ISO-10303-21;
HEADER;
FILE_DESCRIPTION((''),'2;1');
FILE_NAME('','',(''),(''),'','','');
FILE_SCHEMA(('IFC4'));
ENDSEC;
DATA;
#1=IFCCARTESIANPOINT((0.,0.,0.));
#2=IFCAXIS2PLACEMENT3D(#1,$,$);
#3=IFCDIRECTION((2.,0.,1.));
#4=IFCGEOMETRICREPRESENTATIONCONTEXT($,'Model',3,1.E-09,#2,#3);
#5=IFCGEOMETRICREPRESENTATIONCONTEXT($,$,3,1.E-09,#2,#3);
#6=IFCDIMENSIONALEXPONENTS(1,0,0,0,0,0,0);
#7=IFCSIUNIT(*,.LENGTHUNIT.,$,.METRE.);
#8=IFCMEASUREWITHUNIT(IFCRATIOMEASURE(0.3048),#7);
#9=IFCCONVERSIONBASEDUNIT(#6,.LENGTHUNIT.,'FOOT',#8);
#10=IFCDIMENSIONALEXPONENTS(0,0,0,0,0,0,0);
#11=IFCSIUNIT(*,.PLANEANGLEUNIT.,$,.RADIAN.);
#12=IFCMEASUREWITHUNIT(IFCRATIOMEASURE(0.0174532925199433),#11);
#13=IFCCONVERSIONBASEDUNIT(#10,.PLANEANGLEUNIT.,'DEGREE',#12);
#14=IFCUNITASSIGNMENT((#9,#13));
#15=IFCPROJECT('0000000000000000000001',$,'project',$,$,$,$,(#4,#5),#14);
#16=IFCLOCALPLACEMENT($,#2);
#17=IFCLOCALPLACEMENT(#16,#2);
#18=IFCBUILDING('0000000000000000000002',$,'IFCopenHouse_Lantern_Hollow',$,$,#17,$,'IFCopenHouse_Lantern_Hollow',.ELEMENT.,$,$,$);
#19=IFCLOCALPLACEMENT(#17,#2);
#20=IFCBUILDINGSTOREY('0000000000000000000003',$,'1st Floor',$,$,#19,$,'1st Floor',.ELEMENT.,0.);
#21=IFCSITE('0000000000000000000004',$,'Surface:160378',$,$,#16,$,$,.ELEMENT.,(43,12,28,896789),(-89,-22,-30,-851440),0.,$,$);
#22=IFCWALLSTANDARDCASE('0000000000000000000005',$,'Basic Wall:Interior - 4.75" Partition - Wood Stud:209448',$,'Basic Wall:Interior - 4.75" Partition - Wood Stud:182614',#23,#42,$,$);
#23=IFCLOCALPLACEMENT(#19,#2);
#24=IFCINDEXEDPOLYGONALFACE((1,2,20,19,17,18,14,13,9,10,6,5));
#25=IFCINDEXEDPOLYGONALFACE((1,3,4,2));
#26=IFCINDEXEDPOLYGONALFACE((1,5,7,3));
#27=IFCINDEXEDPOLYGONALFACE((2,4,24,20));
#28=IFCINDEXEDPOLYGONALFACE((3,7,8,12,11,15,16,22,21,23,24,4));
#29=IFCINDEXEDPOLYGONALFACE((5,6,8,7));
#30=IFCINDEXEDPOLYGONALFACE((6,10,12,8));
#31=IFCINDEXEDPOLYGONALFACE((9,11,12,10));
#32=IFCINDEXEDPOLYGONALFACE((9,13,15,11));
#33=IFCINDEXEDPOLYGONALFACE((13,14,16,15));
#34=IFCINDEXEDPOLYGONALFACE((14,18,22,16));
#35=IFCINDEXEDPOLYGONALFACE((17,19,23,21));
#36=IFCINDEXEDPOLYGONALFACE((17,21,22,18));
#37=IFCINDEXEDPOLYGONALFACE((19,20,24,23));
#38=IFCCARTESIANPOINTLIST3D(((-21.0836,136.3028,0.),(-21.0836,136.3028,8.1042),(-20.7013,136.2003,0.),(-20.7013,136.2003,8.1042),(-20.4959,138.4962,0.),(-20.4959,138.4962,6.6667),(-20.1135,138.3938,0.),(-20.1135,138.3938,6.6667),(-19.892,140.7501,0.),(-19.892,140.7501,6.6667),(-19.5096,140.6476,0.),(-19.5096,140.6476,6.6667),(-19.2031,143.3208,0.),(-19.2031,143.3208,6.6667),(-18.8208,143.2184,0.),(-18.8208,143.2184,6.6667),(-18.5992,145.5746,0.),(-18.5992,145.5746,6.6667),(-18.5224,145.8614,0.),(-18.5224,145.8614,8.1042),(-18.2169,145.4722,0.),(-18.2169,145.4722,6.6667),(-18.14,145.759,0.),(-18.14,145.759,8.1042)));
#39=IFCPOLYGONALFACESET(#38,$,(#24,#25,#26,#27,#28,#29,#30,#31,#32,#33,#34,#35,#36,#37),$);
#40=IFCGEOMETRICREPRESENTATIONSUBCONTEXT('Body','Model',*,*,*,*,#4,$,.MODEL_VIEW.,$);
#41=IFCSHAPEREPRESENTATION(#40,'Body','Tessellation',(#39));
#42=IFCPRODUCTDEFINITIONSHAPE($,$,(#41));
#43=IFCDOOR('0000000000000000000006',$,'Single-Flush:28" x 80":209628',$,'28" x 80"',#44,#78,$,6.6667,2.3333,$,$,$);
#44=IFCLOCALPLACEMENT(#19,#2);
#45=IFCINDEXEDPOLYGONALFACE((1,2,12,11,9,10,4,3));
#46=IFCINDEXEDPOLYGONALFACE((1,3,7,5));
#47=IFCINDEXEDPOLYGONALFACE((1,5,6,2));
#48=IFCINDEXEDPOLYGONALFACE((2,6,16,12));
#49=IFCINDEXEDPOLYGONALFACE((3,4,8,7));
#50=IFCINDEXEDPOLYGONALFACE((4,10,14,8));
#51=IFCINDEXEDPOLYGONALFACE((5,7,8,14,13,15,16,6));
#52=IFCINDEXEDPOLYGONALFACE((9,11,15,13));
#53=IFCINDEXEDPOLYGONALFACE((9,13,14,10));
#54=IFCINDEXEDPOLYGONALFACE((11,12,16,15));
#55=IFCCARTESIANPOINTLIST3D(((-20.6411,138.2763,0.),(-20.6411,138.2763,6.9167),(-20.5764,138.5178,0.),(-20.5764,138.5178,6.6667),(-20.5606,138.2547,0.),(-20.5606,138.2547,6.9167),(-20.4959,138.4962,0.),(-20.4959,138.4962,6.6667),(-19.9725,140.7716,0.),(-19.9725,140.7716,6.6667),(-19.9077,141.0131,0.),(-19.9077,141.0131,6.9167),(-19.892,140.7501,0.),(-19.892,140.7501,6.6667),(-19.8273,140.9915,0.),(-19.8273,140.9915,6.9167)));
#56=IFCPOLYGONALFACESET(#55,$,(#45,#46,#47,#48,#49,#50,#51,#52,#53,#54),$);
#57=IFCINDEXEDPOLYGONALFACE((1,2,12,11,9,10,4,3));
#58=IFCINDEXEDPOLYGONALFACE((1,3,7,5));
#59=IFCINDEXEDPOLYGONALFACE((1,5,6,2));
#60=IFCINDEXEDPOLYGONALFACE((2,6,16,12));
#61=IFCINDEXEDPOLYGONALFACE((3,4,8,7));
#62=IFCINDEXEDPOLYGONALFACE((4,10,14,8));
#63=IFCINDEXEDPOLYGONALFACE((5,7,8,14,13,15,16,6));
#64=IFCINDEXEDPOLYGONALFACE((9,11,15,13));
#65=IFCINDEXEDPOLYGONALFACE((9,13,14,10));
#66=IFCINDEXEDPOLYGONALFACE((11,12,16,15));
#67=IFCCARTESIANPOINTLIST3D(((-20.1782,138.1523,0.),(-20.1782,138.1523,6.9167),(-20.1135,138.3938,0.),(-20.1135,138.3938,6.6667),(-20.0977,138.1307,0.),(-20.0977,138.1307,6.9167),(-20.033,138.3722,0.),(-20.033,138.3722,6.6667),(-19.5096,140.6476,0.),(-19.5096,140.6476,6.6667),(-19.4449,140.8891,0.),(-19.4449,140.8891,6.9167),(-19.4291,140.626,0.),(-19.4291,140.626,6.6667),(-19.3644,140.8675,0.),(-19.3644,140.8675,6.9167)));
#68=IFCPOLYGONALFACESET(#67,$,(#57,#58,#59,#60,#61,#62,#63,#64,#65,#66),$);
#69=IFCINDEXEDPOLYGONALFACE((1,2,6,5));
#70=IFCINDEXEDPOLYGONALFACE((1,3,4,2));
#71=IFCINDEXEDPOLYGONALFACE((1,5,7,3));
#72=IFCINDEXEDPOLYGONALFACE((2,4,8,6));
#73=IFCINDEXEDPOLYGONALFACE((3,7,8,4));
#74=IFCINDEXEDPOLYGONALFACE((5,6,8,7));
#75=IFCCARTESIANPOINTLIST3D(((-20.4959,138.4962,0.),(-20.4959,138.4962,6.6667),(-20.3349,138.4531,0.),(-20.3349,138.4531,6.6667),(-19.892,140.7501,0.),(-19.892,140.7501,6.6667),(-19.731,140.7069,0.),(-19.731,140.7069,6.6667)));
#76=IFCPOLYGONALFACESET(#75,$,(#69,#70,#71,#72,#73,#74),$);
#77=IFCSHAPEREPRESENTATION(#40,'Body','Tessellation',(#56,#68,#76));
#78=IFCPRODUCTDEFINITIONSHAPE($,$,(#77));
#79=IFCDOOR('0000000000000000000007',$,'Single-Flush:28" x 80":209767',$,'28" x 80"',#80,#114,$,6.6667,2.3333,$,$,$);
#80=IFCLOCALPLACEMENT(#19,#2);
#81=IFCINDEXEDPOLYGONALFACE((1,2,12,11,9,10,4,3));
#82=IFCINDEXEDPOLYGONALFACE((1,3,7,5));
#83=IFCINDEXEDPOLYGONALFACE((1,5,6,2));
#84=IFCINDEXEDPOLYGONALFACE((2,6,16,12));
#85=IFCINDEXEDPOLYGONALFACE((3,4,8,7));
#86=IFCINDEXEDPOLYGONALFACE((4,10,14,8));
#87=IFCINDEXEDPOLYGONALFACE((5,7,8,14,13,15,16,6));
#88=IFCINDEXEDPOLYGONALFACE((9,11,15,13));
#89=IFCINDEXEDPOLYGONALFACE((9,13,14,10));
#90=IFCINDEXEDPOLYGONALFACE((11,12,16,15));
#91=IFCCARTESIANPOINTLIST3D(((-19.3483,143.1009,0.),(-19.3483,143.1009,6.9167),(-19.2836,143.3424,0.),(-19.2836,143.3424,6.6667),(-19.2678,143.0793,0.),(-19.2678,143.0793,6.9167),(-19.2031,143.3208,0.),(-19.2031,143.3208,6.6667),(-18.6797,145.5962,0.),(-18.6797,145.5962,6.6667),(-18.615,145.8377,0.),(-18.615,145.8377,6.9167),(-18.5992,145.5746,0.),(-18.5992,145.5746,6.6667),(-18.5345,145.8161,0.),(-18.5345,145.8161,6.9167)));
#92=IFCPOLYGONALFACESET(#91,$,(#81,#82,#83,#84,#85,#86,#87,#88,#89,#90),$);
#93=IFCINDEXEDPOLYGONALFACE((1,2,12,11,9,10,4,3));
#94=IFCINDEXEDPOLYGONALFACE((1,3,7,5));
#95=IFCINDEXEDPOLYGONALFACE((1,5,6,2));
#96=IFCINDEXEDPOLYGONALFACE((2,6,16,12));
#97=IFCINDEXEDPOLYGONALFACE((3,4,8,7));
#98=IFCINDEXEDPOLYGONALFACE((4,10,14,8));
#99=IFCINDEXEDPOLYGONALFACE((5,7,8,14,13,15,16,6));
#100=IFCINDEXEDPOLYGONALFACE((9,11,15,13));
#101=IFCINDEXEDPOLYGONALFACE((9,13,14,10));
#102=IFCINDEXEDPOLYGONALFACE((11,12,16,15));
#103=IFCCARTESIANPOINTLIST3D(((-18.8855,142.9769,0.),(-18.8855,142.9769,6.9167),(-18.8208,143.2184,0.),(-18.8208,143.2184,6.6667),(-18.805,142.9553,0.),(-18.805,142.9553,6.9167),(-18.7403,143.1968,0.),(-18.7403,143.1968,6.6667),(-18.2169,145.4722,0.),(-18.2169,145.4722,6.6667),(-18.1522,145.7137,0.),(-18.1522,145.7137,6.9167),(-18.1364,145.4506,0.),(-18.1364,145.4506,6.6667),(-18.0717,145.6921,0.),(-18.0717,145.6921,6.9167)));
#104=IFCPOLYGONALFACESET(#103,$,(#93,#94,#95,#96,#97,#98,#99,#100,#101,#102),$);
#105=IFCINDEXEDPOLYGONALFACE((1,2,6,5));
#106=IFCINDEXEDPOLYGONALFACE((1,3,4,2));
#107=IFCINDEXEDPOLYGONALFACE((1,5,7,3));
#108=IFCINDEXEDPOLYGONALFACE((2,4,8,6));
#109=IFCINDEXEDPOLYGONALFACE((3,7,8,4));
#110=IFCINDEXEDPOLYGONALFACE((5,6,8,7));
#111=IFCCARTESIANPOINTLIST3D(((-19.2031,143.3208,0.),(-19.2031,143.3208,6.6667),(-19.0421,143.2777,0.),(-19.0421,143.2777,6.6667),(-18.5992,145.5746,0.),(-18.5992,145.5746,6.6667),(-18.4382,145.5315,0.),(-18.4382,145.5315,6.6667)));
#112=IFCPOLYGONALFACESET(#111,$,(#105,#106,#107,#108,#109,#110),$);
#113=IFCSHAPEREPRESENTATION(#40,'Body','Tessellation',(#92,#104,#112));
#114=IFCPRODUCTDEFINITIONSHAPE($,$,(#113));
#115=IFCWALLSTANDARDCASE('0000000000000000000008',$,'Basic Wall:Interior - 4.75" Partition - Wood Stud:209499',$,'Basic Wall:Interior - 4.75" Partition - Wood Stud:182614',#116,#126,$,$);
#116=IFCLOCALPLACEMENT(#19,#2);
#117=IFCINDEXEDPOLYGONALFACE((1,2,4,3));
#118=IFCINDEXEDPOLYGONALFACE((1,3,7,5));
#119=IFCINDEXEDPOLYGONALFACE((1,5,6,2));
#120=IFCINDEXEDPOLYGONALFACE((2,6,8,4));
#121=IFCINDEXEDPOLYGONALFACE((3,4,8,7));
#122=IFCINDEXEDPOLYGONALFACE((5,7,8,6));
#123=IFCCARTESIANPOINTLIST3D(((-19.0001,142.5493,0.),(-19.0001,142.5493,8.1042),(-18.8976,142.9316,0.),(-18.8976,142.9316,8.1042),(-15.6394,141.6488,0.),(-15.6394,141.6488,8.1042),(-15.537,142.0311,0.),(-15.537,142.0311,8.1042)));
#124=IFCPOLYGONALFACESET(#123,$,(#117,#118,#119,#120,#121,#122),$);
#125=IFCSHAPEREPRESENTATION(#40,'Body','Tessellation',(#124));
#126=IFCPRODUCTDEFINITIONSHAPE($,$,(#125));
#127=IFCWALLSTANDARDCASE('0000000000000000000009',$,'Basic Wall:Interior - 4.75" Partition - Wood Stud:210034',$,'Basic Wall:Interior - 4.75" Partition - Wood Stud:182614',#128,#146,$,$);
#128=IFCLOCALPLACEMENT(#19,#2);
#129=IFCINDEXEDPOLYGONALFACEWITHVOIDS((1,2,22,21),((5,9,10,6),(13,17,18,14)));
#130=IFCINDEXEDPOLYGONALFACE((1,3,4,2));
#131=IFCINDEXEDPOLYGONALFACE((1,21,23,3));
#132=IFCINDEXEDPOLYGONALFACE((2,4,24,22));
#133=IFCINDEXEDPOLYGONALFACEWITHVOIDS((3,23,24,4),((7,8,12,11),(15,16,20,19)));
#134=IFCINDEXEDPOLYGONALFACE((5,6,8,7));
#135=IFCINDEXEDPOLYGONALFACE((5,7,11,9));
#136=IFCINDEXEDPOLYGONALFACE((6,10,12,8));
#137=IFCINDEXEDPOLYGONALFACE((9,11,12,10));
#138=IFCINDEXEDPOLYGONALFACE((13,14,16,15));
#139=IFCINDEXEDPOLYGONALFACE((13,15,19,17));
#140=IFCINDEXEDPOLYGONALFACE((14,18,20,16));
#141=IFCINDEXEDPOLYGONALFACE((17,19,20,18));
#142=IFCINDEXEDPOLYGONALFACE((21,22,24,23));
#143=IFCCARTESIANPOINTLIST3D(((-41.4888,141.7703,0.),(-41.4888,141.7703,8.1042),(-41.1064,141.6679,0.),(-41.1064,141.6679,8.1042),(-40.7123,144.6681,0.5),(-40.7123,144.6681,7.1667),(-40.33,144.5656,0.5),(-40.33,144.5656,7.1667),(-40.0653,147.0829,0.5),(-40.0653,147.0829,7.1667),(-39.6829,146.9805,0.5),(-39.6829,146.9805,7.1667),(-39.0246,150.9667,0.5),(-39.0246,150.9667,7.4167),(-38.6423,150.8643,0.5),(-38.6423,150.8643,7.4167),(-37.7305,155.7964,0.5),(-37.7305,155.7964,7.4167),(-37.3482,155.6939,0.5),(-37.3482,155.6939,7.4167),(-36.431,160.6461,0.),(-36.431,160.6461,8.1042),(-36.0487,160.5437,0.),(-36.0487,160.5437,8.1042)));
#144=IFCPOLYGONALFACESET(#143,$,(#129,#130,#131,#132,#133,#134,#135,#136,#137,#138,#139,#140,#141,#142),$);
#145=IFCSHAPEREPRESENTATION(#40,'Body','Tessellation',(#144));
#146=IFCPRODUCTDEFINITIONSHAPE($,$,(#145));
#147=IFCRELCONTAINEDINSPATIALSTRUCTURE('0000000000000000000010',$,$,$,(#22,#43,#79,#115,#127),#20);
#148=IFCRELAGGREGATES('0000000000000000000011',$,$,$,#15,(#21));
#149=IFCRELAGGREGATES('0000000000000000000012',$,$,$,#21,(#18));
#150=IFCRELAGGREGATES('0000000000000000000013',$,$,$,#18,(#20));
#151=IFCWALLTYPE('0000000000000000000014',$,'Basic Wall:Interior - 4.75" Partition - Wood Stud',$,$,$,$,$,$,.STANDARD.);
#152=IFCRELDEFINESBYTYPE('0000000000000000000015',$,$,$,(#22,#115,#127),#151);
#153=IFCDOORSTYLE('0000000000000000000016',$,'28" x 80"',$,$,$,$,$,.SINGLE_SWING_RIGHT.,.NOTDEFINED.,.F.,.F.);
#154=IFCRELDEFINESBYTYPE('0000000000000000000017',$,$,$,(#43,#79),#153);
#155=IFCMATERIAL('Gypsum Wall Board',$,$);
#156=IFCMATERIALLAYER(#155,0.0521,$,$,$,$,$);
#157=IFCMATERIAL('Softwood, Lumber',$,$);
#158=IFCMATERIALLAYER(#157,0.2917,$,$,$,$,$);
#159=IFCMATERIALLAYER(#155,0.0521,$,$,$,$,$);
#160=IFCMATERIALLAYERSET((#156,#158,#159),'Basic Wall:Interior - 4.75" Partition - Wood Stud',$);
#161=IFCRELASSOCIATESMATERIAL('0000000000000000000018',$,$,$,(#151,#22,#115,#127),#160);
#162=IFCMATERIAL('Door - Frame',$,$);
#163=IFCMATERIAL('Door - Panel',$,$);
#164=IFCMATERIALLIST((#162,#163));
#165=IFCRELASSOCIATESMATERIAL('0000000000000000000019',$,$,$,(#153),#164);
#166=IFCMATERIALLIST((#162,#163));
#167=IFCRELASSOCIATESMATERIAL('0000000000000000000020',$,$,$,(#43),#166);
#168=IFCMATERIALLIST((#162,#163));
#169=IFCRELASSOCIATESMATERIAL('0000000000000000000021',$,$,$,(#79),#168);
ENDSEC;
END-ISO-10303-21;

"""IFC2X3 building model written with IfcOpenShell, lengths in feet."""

from ifc_helpers import new_model, entity, si_unit, converted_unit, direction, frame, frame_2d, origin, origin_2d_with_axis, place, context, subcontext, project, spatial, polyline, rectangle, outline, extrude, source, transform, mapped, material, material_list, layer, layer_set, layer_usage, type_object, type_shapes, element, fill, save


model = new_model("IFC2X3")

# Units and contexts
model_context = context("Model", 3, precision=1e-09, world=origin(), true_north=direction((2.0, 0.0, 1.0)))
context_of_model = context(None, 3, precision=1e-09, world=origin(), true_north=direction((2.0, 0.0, 1.0)))
body_context = subcontext(model_context, "Body", "Model", "MODEL_VIEW")
ifc_project = project(units=[converted_unit("LENGTHUNIT", "FOOT", entity("IfcRatioMeasure", 0.3048), si_unit("LENGTHUNIT", "METRE"), dimensions=[1, 0, 0, 0, 0, 0, 0]), converted_unit("PLANEANGLEUNIT", "DEGREE", entity("IfcRatioMeasure", 0.0174532925199433), si_unit("PLANEANGLEUNIT", "RADIAN"), dimensions=[0, 0, 0, 0, 0, 0, 0])], contexts=[model_context, context_of_model])

# Site, building, storey
site_placement = place(None, origin())
site = spatial("IfcSite", under=ifc_project, at=site_placement, Name="Surface:160378", CompositionType="ELEMENT", RefLatitude=(43, 12, 28, 896789), RefLongitude=(-89, -22, -30, -851440), RefElevation=0.0)
building_placement = place(site_placement, origin())
building = spatial("IfcBuilding", under=site, at=building_placement, Name="IFCopenHouse_Lantern_Hollow", LongName="IFCopenHouse_Lantern_Hollow", CompositionType="ELEMENT")
storey_placement = place(building_placement, origin())
storey = spatial("IfcBuildingStorey", under=building, at=storey_placement, Name="1st Floor", LongName="1st Floor", CompositionType="ELEMENT", Elevation=0.0)

# Shared definitions
ifc_material_1 = material(Name="Gypsum Wall Board")
ifc_layer_1 = layer(ifc_material_1, 0.0521)
ifc_material_2 = material(Name="Softwood, Lumber")
ifc_layer_2 = layer(ifc_material_2, 0.2917)
ifc_layer_3 = layer(ifc_material_1, 0.0521)
ifc_layer_set_1 = layer_set([ifc_layer_1, ifc_layer_2, ifc_layer_3], Name="Basic Wall:Interior - 4.75\" Partition - Wood Stud")
wall_type_1 = type_object("IfcWallType", Name="Basic Wall:Interior - 4.75\" Partition - Wood Stud", PredefinedType="STANDARD", material=ifc_layer_set_1)

# Shared definitions
ifc_material_3 = material(Name="Door - Panel")
ifc_material_4 = material(Name="Door - Frame")

# Wall, openings, doors
ifc_layer_usage_1 = layer_usage(ifc_layer_set_1, "AXIS2", "NEGATIVE", 0.1979)
wall_1_placement = place(storey_placement, frame((-18.3312, 145.8102, 0.0), z_axis=(0.0, 0.0, 1.0), x_axis=(-0.258819, -0.965926, 0.0)))
wall_1 = element("IfcWallStandardCase", 1, at=wall_1_placement, inside=storey, type_object=wall_type_1, material=ifc_layer_usage_1, Name="Basic Wall:Interior - 4.75\" Partition - Wood Stud:209448", ObjectType="Basic Wall:Interior - 4.75\" Partition - Wood Stud:182614", context=body_context, shape_type="SweptSolid", body=[
    extrude(rectangle(XDim=9.8958, YDim=0.3958, at=frame_2d((4.9479, 0.0), x_axis=(-1.0, 0.0))), origin(), (0.0, 0.0, 1.0), 8.1042),
])
opening_1_placement = place(wall_1_placement, frame((7.625, 0.1979, 0.0)))
opening_1 = element("IfcOpeningElement", 2, at=opening_1_placement, cuts=wall_1, ObjectType="Opening", context=body_context, shape_type="SweptSolid", body=[
    extrude(rectangle(XDim=2.3333, YDim=6.6667, at=frame_2d((3.3333, 1.1667), x_axis=(0.0, 1.0))), frame((0.0, 0.0, 0.0), z_axis=(0.0, -1.0, 0.0), x_axis=(0.0, 0.0, 1.0)), (0.0, 0.0, 1.0), 0.3958),
])
opening_2_placement = place(wall_1_placement, frame((2.6302, 0.1979, 0.0)))
opening_2 = element("IfcOpeningElement", 3, at=opening_2_placement, cuts=wall_1, ObjectType="Opening", context=body_context, shape_type="SweptSolid", body=[
    extrude(rectangle(XDim=2.3333, YDim=6.6667, at=frame_2d((3.3333, 1.1667), x_axis=(0.0, 1.0))), frame((0.0, 0.0, 0.0), z_axis=(0.0, -1.0, 0.0), x_axis=(0.0, 0.0, 1.0)), (0.0, 0.0, 1.0), 0.3958),
])
ifc_material_list_1 = material_list([ifc_material_4, ifc_material_3])
ifc_material_list_2 = material_list([ifc_material_4, ifc_material_3])
door_style_1 = type_object("IfcDoorStyle", Name="28\" x 80\"", ConstructionType="NOTDEFINED", OperationType="SINGLE_SWING_RIGHT", ParameterTakesPrecedence=False, Sizeable=False, material=ifc_material_list_2)
shared_shape_1 = source(origin(), body_context, "Body", "SweptSolid", [
    extrude(outline(polyline([(-1.4167, -3.5208), (1.4167, -3.5208), (1.4167, 3.3958), (1.1667, 3.3958), (1.1667, -3.2708), (-1.1667, -3.2708), (-1.1667, 3.3958), (-1.4167, 3.3958), (-1.4167, -3.5208)])), frame((1.1667, 0.3958, 3.3958), z_axis=(0.0, 1.0, 0.0), x_axis=(1.0, 0.0, 0.0)), (0.0, 0.0, 1.0), 0.0833),
    extrude(outline(polyline([(-3.5208, -1.4167), (3.3958, -1.4167), (3.3958, -1.1667), (-3.2708, -1.1667), (-3.2708, 1.1667), (3.3958, 1.1667), (3.3958, 1.4167), (-3.5208, 1.4167), (-3.5208, -1.4167)])), frame((1.1667, -0.0833, 3.3958), z_axis=(0.0, 1.0, 0.0), x_axis=(0.0, 0.0, -1.0)), (0.0, 0.0, 1.0), 0.0833),
    extrude(rectangle(XDim=0.1667, YDim=2.3333, at=frame_2d((0.0, 0.0), x_axis=(1.0, 0.0))), frame((1.1667, 0.3125, 0.0), z_axis=(0.0, 0.0, 1.0), x_axis=(0.0, 1.0, 0.0)), (0.0, 0.0, 1.0), 6.6667),
])
type_shapes(door_style_1, [shared_shape_1])
door_1_placement = place(storey_placement, frame((-20.1135, 138.3938, 0.0), z_axis=(0.0, 0.0, 1.0), x_axis=(0.258819, 0.965926, 0.0)))
door_1 = element("IfcDoor", 4, at=door_1_placement, inside=storey, type_object=door_style_1, material=ifc_material_list_1, Name="Single-Flush:28\" x 80\":209628", ObjectType="28\" x 80\"", OverallHeight=6.6667, OverallWidth=2.3333, context=body_context, shape_type="MappedRepresentation", body=[
    mapped(shared_shape_1, transform((0.0, 0.0, 0.0), scale=1.0)),
])
fill(opening_1, door_1)
ifc_material_list_3 = material_list([ifc_material_4, ifc_material_3])
door_2_placement = place(storey_placement, frame((-18.8208, 143.2184, 0.0), z_axis=(0.0, 0.0, 1.0), x_axis=(0.258819, 0.965926, 0.0)))
door_2 = element("IfcDoor", 5, at=door_2_placement, inside=storey, type_object=door_style_1, material=ifc_material_list_3, Name="Single-Flush:28\" x 80\":209767", ObjectType="28\" x 80\"", OverallHeight=6.6667, OverallWidth=2.3333, context=body_context, shape_type="MappedRepresentation", body=[
    mapped(shared_shape_1, transform((0.0, 0.0, 0.0), scale=1.0)),
])
fill(opening_2, door_2)

# Wall
ifc_layer_usage_2 = layer_usage(ifc_layer_set_1, "AXIS2", "NEGATIVE", 0.1979)
wall_2_placement = place(storey_placement, frame((-18.9488, 142.7404, 0.0), z_axis=(0.0, 0.0, 1.0), x_axis=(0.965926, -0.258819, 0.0)))
element("IfcWallStandardCase", 6, at=wall_2_placement, inside=storey, type_object=wall_type_1, material=ifc_layer_usage_2, Name="Basic Wall:Interior - 4.75\" Partition - Wood Stud:209499", ObjectType="Basic Wall:Interior - 4.75\" Partition - Wood Stud:182614", context=body_context, shape_type="SweptSolid", body=[
    extrude(rectangle(XDim=3.4792, YDim=0.3958, at=frame_2d((1.7396, 0.0), x_axis=(-1.0, 0.0))), origin(), (0.0, 0.0, 1.0), 8.1042),
])

# Wall, openings
ifc_layer_usage_3 = layer_usage(ifc_layer_set_1, "AXIS2", "NEGATIVE", 0.1979)
wall_3_placement = place(storey_placement, frame((-36.2399, 160.5949, 0.0), z_axis=(0.0, 0.0, 1.0), x_axis=(-0.258819, -0.965926, 0.0)))
wall_3 = element("IfcWallStandardCase", 7, at=wall_3_placement, inside=storey, type_object=wall_type_1, material=ifc_layer_usage_3, Name="Basic Wall:Interior - 4.75\" Partition - Wood Stud:210034", ObjectType="Basic Wall:Interior - 4.75\" Partition - Wood Stud:182614", context=body_context, shape_type="SweptSolid", body=[
    extrude(rectangle(XDim=19.5417, YDim=0.3958, at=frame_2d((9.7708, 0.0), x_axis=(-1.0, 0.0))), origin(), (0.0, 0.0, 1.0), 8.1042),
])
opening_3_placement = place(wall_3_placement, origin())
element("IfcOpeningElement", 8, at=opening_3_placement, cuts=wall_3, ObjectType="Opening", context=body_context, shape_type="SweptSolid", body=[
    extrude(rectangle(XDim=6.9167, YDim=5.0, at=origin_2d_with_axis()), frame((7.5208, -0.1979, 3.9583), z_axis=(0.0, 1.0, 0.0), x_axis=(0.0, 0.0, -1.0)), (0.0, 0.0, 1.0), 0.3958),
])
opening_4_placement = place(wall_3_placement, origin())
element("IfcOpeningElement", 9, at=opening_4_placement, cuts=wall_3, ObjectType="Opening", context=body_context, shape_type="SweptSolid", body=[
    extrude(rectangle(XDim=6.6667, YDim=2.5, at=origin_2d_with_axis()), frame((15.2917, -0.1979, 3.8333), z_axis=(0.0, 1.0, 0.0), x_axis=(0.0, 0.0, -1.0)), (0.0, 0.0, 1.0), 0.3958),
])

save(model, "model.ifc")
